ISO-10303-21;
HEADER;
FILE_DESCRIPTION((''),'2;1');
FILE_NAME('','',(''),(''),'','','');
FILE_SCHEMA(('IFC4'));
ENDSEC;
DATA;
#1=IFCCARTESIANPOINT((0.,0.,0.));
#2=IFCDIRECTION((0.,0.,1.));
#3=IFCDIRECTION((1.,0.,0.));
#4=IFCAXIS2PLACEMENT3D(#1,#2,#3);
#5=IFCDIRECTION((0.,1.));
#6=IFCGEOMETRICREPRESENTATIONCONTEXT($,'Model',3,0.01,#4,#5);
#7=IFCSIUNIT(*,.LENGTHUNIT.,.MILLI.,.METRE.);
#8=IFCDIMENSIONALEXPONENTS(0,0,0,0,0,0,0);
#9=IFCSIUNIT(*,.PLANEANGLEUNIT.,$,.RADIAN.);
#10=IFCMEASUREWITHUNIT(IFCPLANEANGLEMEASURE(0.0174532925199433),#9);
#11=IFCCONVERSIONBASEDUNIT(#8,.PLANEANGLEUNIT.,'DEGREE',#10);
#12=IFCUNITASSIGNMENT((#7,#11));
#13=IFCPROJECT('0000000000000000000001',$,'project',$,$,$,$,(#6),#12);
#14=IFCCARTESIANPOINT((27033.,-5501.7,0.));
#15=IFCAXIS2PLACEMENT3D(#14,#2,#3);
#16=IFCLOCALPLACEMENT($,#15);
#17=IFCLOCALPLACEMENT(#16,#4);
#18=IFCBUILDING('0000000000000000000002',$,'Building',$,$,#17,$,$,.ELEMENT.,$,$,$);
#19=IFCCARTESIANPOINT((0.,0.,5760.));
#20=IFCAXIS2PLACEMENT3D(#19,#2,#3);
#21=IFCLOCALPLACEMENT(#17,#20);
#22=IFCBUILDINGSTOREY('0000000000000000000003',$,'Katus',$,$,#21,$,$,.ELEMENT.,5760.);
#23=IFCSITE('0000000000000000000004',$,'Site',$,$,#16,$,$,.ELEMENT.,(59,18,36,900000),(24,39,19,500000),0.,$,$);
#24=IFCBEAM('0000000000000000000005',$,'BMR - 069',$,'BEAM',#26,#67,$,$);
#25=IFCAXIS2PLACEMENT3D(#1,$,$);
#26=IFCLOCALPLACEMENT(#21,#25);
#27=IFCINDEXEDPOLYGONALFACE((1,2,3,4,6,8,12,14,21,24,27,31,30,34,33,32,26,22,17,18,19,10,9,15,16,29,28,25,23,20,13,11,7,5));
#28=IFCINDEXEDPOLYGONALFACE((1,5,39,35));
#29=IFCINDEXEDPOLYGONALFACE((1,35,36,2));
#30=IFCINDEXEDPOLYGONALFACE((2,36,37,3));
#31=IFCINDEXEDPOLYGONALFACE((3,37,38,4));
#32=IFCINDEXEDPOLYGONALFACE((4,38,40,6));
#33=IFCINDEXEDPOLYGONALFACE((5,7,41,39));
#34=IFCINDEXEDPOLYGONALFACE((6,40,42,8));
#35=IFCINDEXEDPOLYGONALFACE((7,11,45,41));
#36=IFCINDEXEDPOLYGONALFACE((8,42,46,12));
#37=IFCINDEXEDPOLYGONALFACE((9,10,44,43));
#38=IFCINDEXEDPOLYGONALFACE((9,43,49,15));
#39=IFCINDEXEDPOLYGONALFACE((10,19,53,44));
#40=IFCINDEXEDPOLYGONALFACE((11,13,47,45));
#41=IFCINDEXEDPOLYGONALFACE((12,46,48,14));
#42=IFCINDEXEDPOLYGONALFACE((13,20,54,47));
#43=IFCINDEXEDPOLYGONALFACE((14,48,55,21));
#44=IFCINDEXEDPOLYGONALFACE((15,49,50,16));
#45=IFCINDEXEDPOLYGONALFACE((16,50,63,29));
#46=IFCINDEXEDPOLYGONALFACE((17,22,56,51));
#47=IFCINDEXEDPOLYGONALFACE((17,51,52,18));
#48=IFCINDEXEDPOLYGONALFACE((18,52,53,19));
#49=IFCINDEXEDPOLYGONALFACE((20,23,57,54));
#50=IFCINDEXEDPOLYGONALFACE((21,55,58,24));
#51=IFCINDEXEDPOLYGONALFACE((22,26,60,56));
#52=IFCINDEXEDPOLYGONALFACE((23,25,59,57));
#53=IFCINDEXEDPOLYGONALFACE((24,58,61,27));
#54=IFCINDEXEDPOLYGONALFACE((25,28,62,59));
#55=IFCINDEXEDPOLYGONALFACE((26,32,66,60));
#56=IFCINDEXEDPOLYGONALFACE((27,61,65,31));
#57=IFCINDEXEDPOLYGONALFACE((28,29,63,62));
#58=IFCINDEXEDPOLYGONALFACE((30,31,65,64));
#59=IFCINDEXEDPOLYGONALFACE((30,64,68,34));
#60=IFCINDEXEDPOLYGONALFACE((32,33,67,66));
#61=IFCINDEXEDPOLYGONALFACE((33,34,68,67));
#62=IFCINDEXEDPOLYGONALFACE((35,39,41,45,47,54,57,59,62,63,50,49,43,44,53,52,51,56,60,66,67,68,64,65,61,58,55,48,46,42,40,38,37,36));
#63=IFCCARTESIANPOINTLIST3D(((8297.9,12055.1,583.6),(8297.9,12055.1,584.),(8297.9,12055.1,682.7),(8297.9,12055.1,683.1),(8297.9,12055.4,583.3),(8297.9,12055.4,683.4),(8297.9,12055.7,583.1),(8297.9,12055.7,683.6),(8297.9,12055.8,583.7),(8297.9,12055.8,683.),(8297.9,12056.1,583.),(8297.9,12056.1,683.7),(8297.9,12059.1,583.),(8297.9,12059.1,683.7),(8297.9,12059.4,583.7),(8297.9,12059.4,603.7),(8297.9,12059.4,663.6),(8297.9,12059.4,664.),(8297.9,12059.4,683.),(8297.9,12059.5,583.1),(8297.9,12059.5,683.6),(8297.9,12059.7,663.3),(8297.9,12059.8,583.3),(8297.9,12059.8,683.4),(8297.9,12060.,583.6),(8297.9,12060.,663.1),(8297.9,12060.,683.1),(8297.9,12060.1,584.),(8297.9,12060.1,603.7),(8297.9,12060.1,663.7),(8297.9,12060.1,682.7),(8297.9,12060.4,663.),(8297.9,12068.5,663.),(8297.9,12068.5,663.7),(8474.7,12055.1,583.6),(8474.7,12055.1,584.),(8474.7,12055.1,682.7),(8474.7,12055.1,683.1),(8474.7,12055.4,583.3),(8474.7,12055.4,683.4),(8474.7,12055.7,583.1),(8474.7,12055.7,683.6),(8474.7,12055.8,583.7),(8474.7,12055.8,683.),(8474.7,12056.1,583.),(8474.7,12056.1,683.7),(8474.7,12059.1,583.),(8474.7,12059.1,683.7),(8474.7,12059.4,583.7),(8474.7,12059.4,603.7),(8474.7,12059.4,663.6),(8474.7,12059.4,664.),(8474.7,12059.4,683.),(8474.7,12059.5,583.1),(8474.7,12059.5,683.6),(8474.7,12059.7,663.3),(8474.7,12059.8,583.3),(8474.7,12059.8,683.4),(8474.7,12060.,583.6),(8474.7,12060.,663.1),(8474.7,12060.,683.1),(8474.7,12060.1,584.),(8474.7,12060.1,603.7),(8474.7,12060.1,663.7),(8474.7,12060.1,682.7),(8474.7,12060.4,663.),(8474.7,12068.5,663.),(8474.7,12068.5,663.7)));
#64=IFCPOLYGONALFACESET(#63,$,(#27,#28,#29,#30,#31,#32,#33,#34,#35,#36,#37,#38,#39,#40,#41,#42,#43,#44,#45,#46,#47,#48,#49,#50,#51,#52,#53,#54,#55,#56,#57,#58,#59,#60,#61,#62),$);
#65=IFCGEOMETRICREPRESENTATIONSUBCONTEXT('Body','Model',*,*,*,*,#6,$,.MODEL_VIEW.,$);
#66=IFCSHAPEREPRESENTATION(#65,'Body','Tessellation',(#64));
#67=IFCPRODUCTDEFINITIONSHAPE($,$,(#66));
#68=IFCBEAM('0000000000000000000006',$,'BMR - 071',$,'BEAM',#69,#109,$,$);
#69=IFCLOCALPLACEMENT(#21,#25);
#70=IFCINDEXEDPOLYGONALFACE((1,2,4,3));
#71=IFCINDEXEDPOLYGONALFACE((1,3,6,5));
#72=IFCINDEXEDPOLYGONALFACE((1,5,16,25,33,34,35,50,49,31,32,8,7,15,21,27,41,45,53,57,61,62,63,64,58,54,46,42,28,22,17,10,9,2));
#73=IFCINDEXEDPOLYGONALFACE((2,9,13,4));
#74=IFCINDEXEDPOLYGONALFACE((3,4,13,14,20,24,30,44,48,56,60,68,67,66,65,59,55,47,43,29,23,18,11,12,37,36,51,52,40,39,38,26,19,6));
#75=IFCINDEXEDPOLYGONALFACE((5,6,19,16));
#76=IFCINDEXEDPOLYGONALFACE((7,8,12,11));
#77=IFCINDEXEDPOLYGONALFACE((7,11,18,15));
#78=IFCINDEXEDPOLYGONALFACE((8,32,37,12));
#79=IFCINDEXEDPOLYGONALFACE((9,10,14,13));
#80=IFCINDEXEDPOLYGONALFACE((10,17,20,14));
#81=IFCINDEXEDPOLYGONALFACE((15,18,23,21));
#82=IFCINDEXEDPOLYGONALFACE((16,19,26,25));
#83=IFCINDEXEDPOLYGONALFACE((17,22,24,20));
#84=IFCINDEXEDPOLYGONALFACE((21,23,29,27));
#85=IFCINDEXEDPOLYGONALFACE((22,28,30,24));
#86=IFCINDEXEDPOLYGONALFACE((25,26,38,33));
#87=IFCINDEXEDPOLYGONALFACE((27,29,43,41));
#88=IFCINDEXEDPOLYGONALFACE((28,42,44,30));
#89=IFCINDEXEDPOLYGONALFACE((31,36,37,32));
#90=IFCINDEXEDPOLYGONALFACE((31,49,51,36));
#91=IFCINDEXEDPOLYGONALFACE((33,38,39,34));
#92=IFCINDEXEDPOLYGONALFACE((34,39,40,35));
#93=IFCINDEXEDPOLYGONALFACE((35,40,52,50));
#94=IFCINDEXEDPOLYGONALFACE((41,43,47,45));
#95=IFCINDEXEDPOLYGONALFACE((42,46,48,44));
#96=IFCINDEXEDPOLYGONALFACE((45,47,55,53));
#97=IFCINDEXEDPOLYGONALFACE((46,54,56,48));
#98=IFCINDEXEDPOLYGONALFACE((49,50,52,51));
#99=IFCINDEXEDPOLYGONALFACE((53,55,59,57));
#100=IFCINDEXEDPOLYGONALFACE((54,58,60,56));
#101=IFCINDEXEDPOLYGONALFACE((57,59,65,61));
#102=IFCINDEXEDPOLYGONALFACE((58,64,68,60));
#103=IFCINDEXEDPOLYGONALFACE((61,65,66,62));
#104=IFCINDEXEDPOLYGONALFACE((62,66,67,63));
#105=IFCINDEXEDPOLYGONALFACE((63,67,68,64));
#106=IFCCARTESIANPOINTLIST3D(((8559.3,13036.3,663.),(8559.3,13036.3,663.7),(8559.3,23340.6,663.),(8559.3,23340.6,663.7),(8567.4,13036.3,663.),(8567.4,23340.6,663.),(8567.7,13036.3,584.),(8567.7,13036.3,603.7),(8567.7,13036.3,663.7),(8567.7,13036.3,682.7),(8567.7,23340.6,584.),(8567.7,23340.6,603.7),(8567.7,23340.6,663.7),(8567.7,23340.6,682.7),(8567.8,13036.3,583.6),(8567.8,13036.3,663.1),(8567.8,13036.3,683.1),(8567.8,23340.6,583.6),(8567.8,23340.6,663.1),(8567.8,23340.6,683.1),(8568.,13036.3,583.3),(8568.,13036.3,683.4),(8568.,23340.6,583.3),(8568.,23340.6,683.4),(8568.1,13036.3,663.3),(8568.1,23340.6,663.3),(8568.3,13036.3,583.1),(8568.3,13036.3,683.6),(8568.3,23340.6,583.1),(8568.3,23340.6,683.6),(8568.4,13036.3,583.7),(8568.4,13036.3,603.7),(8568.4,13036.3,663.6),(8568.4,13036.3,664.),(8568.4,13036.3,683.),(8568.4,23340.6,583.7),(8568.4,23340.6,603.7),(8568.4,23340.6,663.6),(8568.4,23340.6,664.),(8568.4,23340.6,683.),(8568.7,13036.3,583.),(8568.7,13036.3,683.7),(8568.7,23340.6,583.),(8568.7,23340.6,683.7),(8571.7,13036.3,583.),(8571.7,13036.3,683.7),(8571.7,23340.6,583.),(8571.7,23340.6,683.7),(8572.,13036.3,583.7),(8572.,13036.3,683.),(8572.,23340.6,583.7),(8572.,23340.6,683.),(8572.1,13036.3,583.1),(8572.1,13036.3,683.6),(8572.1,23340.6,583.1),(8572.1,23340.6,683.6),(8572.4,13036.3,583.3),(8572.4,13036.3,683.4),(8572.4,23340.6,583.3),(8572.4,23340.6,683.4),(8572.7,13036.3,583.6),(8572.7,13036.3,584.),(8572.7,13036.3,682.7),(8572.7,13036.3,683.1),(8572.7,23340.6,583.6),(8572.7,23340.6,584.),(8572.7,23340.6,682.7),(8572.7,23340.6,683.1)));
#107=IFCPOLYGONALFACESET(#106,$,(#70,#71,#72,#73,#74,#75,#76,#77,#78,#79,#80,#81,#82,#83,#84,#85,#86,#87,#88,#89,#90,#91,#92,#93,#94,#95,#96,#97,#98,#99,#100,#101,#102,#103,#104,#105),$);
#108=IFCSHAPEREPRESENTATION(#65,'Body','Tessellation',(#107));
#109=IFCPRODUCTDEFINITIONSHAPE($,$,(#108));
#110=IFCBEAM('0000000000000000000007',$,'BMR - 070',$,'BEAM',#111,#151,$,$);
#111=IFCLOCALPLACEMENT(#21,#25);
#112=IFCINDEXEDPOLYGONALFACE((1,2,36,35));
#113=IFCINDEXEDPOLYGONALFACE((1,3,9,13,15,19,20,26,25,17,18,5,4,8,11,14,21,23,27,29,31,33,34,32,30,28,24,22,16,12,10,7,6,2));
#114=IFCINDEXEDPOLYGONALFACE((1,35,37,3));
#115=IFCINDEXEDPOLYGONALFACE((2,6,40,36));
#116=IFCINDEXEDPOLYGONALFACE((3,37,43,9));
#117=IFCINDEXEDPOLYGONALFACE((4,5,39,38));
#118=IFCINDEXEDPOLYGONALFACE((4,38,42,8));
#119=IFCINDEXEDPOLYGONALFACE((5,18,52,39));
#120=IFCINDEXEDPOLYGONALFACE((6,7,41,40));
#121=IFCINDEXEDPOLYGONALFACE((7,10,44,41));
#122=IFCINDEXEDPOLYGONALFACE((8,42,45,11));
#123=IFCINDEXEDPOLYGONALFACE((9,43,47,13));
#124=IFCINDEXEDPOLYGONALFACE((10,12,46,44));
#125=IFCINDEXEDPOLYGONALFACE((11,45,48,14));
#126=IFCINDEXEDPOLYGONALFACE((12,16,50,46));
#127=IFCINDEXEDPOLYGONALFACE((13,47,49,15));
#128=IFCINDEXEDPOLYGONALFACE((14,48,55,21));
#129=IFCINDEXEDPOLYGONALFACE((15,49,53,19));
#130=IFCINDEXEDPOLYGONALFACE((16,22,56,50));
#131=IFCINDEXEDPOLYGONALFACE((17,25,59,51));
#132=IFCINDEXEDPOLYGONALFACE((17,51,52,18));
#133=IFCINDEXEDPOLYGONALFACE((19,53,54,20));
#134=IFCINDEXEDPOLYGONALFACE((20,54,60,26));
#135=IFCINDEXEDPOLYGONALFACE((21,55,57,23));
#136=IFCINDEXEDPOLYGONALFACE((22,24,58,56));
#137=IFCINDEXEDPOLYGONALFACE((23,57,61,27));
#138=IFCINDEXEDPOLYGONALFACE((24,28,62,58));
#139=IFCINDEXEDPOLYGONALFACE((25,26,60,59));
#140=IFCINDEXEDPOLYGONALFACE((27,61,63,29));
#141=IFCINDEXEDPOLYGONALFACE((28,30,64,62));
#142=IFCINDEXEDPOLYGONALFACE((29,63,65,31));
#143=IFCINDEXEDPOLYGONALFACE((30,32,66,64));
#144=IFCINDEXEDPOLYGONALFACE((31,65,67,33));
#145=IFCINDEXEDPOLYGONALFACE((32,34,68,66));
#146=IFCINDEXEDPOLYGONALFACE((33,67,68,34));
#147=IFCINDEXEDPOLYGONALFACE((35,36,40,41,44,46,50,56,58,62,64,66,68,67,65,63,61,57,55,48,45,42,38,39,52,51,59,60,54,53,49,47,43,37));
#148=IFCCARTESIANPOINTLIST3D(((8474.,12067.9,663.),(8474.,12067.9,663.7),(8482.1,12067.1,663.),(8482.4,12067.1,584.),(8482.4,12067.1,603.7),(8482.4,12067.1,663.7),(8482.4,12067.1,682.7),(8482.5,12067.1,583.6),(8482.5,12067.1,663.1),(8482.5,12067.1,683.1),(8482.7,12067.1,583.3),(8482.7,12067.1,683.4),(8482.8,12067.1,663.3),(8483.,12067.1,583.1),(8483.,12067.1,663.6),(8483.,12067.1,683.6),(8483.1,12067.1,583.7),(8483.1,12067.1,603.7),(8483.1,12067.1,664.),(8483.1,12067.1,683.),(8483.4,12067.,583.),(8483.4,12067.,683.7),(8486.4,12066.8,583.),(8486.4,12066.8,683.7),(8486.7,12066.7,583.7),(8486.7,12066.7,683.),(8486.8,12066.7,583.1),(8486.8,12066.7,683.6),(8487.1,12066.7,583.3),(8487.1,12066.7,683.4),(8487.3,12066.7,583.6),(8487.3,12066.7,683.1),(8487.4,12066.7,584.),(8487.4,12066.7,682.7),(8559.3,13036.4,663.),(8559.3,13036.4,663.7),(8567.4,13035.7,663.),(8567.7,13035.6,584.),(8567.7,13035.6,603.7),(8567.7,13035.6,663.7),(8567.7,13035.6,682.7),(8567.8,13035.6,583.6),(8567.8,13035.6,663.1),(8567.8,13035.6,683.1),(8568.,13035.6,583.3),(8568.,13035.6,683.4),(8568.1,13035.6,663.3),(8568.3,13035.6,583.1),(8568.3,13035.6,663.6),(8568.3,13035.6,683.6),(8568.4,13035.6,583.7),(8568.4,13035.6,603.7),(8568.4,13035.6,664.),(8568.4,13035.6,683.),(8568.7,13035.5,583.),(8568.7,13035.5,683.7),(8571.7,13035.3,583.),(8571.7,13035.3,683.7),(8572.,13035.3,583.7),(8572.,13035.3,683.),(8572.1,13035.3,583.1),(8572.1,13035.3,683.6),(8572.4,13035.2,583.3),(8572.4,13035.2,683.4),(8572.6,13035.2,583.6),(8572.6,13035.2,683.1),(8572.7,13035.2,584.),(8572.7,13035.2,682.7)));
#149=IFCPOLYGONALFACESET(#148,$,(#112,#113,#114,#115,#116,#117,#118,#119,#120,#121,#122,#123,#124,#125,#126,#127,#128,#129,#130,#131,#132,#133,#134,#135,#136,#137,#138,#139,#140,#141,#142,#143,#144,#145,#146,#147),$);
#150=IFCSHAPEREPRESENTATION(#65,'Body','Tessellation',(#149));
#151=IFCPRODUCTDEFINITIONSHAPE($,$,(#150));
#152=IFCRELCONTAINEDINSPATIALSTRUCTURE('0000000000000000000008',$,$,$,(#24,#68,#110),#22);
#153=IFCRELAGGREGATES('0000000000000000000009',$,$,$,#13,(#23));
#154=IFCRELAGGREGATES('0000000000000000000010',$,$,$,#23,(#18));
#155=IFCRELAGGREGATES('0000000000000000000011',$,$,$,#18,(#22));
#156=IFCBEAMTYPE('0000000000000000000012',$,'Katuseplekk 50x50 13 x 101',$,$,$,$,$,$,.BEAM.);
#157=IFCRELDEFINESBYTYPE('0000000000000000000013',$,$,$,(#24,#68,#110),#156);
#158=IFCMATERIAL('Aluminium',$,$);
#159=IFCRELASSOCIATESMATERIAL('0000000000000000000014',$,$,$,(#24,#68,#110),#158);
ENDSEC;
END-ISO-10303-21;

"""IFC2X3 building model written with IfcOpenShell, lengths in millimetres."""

from ifc_helpers import new_model, entity, si_unit, converted_unit, point, direction, frame, frame_2d, origin_with_axes, place, context, subcontext, project, spatial, polyline, circle_curve, parameter, trimmed, segment, composite_curve, outline, extrude, material, type_object, element, save


model = new_model("IFC2X3")

# Units and contexts
model_context = context("Model", 3, precision=0.01, world=origin_with_axes(), true_north=direction((0.0, 1.0)))
body_context = subcontext(model_context, "Body", "Model", "MODEL_VIEW")
ifc_project = project(units=[si_unit("LENGTHUNIT", "METRE", prefix="MILLI"), converted_unit("PLANEANGLEUNIT", "DEGREE", entity("IfcPlaneAngleMeasure", 0.0174532925199433), si_unit("PLANEANGLEUNIT", "RADIAN"), dimensions=[0, 0, 0, 0, 0, 0, 0])], contexts=[model_context])

# Site, building, storey
site_placement = place(None, frame((27033.0, -5501.7, 0.0), z_axis=(0.0, 0.0, 1.0), x_axis=(1.0, 0.0, 0.0)))
site = spatial("IfcSite", under=ifc_project, at=site_placement, Name="Site", CompositionType="ELEMENT", RefLatitude=(59, 18, 36, 900000), RefLongitude=(24, 39, 19, 500000), RefElevation=0.0)
building_placement = place(site_placement, origin_with_axes())
building = spatial("IfcBuilding", under=site, at=building_placement, Name="Building", CompositionType="ELEMENT")
storey_placement = place(building_placement, frame((0.0, 0.0, 5760.0), z_axis=(0.0, 0.0, 1.0), x_axis=(1.0, 0.0, 0.0)))
storey = spatial("IfcBuildingStorey", under=building, at=storey_placement, Name="Katus", CompositionType="ELEMENT", Elevation=5760.0)

# Beams
ifc_material_1 = material(Name="Aluminium")
beam_type = type_object("IfcBeamType", Name="Katuseplekk 50x50 13 x 101", PredefinedType="BEAM")
beam_1_placement = place(storey_placement, frame((8297.9, 12067.8, 663.0), z_axis=(0.0, 0.0, 1.0), x_axis=(0.0, -1.0, 0.0)))
element("IfcBeam", 1, at=beam_1_placement, inside=storey, type_object=beam_type, material=ifc_material_1, Name="BMR - 069", ObjectType="BEAM", context=body_context, shape_type="SweptSolid", body=[
    extrude(outline(composite_curve([segment(polyline([(-0.7, 0.0), (7.4, 0.0)]), True, "CONTINUOUS"), segment(trimmed(circle_curve(frame_2d((7.4, 1.0), x_axis=(0.0, -1.0)), 1.0), [point((7.4, 0.0)), parameter(0.0)], [point((8.4, 1.0)), parameter(90.0)], True, "CARTESIAN"), True, "CONTINUOUS"), segment(polyline([(8.4, 1.0), (8.4, 20.0), (12.0, 20.0), (12.0, -79.3), (8.4, -79.3), (8.4, -59.3), (7.7, -59.3), (7.7, -79.0)]), True, "CONTINUOUS"), segment(trimmed(circle_curve(frame_2d((8.7, -79.0), x_axis=(-1.0, 0.0)), 1.0), [point((7.7, -79.0)), parameter(0.0)], [point((8.7, -80.0)), parameter(90.0)], True, "CARTESIAN"), True, "CONTINUOUS"), segment(polyline([(8.7, -80.0), (11.7, -80.0)]), True, "CONTINUOUS"), segment(trimmed(circle_curve(frame_2d((11.7, -79.0), x_axis=(0.0, -1.0)), 1.0), [point((11.7, -80.0)), parameter(0.0)], [point((12.7, -79.0)), parameter(90.0)], True, "CARTESIAN"), True, "CONTINUOUS"), segment(polyline([(12.7, -79.0), (12.7, 19.7)]), True, "CONTINUOUS"), segment(trimmed(circle_curve(frame_2d((11.7, 19.7), x_axis=(1.0, 0.0)), 1.0), [point((12.7, 19.7)), parameter(0.0)], [point((11.7, 20.7)), parameter(90.0)], True, "CARTESIAN"), True, "CONTINUOUS"), segment(polyline([(11.7, 20.7), (8.7, 20.7)]), True, "CONTINUOUS"), segment(trimmed(circle_curve(frame_2d((8.7, 19.7), x_axis=(0.0, 1.0)), 1.0), [point((8.7, 20.7)), parameter(0.0)], [point((7.7, 19.7)), parameter(90.0)], True, "CARTESIAN"), True, "CONTINUOUS"), segment(polyline([(7.7, 19.7), (7.7, 0.7), (-0.7, 0.7), (-0.7, 0.0)]), True, "CONTINUOUS")], self_intersect=False)), frame((0.0, 176.8, 0.0), z_axis=(0.0, -1.0, 0.0), x_axis=(1.0, 0.0, 0.0)), (0.0, 0.0, 1.0), 176.8),
])
beam_2_placement = place(storey_placement, frame((8560.0, 13036.3, 663.0), z_axis=(0.0, 0.0, 1.0), x_axis=(1.0, 0.0, 0.0)))
element("IfcBeam", 2, at=beam_2_placement, inside=storey, type_object=beam_type, material=ifc_material_1, Name="BMR - 071", ObjectType="BEAM", context=body_context, shape_type="SweptSolid", body=[
    extrude(outline(composite_curve([segment(polyline([(-0.7, 0.0), (7.4, 0.0)]), True, "CONTINUOUS"), segment(trimmed(circle_curve(frame_2d((7.4, 1.0), x_axis=(0.0, -1.0)), 1.0), [point((7.4, 0.0)), parameter(0.0)], [point((8.4, 1.0)), parameter(90.0)], True, "CARTESIAN"), True, "CONTINUOUS"), segment(polyline([(8.4, 1.0), (8.4, 20.0), (12.0, 20.0), (12.0, -79.3), (8.4, -79.3), (8.4, -59.3), (7.7, -59.3), (7.7, -79.0)]), True, "CONTINUOUS"), segment(trimmed(circle_curve(frame_2d((8.7, -79.0), x_axis=(-1.0, 0.0)), 1.0), [point((7.7, -79.0)), parameter(0.0)], [point((8.7, -80.0)), parameter(90.0)], True, "CARTESIAN"), True, "CONTINUOUS"), segment(polyline([(8.7, -80.0), (11.7, -80.0)]), True, "CONTINUOUS"), segment(trimmed(circle_curve(frame_2d((11.7, -79.0), x_axis=(0.0, -1.0)), 1.0), [point((11.7, -80.0)), parameter(0.0)], [point((12.7, -79.0)), parameter(90.0)], True, "CARTESIAN"), True, "CONTINUOUS"), segment(polyline([(12.7, -79.0), (12.7, 19.7)]), True, "CONTINUOUS"), segment(trimmed(circle_curve(frame_2d((11.7, 19.7), x_axis=(1.0, 0.0)), 1.0), [point((12.7, 19.7)), parameter(0.0)], [point((11.7, 20.7)), parameter(90.0)], True, "CARTESIAN"), True, "CONTINUOUS"), segment(polyline([(11.7, 20.7), (8.7, 20.7)]), True, "CONTINUOUS"), segment(trimmed(circle_curve(frame_2d((8.7, 19.7), x_axis=(0.0, 1.0)), 1.0), [point((8.7, 20.7)), parameter(0.0)], [point((7.7, 19.7)), parameter(90.0)], True, "CARTESIAN"), True, "CONTINUOUS"), segment(polyline([(7.7, 19.7), (7.7, 0.7), (-0.7, 0.7), (-0.7, 0.0)]), True, "CONTINUOUS")], self_intersect=False)), frame((0.0, 10304.3, 0.0), z_axis=(0.0, -1.0, 0.0), x_axis=(1.0, 0.0, 0.0)), (0.0, 0.0, 1.0), 10304.3),
])
beam_3_placement = place(storey_placement, frame((8474.7, 12067.8, 663.0), z_axis=(0.0, 0.0, 1.0), x_axis=(0.996146, -0.087713, 0.0)))
element("IfcBeam", 3, at=beam_3_placement, inside=storey, type_object=beam_type, material=ifc_material_1, Name="BMR - 070", ObjectType="BEAM", context=body_context, shape_type="SweptSolid", body=[
    extrude(outline(composite_curve([segment(polyline([(-0.7, 0.0), (7.4, 0.0)]), True, "CONTINUOUS"), segment(trimmed(circle_curve(frame_2d((7.4, 1.0), x_axis=(0.0, -1.0)), 1.0), [point((7.4, 0.0)), parameter(0.0)], [point((8.4, 1.0)), parameter(90.0)], True, "CARTESIAN"), True, "CONTINUOUS"), segment(polyline([(8.4, 1.0), (8.4, 20.0), (12.0, 20.0), (12.0, -79.3), (8.4, -79.3), (8.4, -59.3), (7.7, -59.3), (7.7, -79.0)]), True, "CONTINUOUS"), segment(trimmed(circle_curve(frame_2d((8.7, -79.0), x_axis=(-1.0, 0.0)), 1.0), [point((7.7, -79.0)), parameter(0.0)], [point((8.7, -80.0)), parameter(90.0)], True, "CARTESIAN"), True, "CONTINUOUS"), segment(polyline([(8.7, -80.0), (11.7, -80.0)]), True, "CONTINUOUS"), segment(trimmed(circle_curve(frame_2d((11.7, -79.0), x_axis=(0.0, -1.0)), 1.0), [point((11.7, -80.0)), parameter(0.0)], [point((12.7, -79.0)), parameter(90.0)], True, "CARTESIAN"), True, "CONTINUOUS"), segment(polyline([(12.7, -79.0), (12.7, 19.7)]), True, "CONTINUOUS"), segment(trimmed(circle_curve(frame_2d((11.7, 19.7), x_axis=(1.0, 0.0)), 1.0), [point((12.7, 19.7)), parameter(0.0)], [point((11.7, 20.7)), parameter(90.0)], True, "CARTESIAN"), True, "CONTINUOUS"), segment(polyline([(11.7, 20.7), (8.7, 20.7)]), True, "CONTINUOUS"), segment(trimmed(circle_curve(frame_2d((8.7, 19.7), x_axis=(0.0, 1.0)), 1.0), [point((8.7, 20.7)), parameter(0.0)], [point((7.7, 19.7)), parameter(90.0)], True, "CARTESIAN"), True, "CONTINUOUS"), segment(polyline([(7.7, 19.7), (7.7, 0.7), (-0.7, 0.7), (-0.7, 0.0)]), True, "CONTINUOUS")], self_intersect=False)), frame((0.0, 972.3, 0.0), z_axis=(0.0, -1.0, 0.0), x_axis=(1.0, 0.0, 0.0)), (0.0, 0.0, 1.0), 972.3),
])

save(model, "model.ifc")
